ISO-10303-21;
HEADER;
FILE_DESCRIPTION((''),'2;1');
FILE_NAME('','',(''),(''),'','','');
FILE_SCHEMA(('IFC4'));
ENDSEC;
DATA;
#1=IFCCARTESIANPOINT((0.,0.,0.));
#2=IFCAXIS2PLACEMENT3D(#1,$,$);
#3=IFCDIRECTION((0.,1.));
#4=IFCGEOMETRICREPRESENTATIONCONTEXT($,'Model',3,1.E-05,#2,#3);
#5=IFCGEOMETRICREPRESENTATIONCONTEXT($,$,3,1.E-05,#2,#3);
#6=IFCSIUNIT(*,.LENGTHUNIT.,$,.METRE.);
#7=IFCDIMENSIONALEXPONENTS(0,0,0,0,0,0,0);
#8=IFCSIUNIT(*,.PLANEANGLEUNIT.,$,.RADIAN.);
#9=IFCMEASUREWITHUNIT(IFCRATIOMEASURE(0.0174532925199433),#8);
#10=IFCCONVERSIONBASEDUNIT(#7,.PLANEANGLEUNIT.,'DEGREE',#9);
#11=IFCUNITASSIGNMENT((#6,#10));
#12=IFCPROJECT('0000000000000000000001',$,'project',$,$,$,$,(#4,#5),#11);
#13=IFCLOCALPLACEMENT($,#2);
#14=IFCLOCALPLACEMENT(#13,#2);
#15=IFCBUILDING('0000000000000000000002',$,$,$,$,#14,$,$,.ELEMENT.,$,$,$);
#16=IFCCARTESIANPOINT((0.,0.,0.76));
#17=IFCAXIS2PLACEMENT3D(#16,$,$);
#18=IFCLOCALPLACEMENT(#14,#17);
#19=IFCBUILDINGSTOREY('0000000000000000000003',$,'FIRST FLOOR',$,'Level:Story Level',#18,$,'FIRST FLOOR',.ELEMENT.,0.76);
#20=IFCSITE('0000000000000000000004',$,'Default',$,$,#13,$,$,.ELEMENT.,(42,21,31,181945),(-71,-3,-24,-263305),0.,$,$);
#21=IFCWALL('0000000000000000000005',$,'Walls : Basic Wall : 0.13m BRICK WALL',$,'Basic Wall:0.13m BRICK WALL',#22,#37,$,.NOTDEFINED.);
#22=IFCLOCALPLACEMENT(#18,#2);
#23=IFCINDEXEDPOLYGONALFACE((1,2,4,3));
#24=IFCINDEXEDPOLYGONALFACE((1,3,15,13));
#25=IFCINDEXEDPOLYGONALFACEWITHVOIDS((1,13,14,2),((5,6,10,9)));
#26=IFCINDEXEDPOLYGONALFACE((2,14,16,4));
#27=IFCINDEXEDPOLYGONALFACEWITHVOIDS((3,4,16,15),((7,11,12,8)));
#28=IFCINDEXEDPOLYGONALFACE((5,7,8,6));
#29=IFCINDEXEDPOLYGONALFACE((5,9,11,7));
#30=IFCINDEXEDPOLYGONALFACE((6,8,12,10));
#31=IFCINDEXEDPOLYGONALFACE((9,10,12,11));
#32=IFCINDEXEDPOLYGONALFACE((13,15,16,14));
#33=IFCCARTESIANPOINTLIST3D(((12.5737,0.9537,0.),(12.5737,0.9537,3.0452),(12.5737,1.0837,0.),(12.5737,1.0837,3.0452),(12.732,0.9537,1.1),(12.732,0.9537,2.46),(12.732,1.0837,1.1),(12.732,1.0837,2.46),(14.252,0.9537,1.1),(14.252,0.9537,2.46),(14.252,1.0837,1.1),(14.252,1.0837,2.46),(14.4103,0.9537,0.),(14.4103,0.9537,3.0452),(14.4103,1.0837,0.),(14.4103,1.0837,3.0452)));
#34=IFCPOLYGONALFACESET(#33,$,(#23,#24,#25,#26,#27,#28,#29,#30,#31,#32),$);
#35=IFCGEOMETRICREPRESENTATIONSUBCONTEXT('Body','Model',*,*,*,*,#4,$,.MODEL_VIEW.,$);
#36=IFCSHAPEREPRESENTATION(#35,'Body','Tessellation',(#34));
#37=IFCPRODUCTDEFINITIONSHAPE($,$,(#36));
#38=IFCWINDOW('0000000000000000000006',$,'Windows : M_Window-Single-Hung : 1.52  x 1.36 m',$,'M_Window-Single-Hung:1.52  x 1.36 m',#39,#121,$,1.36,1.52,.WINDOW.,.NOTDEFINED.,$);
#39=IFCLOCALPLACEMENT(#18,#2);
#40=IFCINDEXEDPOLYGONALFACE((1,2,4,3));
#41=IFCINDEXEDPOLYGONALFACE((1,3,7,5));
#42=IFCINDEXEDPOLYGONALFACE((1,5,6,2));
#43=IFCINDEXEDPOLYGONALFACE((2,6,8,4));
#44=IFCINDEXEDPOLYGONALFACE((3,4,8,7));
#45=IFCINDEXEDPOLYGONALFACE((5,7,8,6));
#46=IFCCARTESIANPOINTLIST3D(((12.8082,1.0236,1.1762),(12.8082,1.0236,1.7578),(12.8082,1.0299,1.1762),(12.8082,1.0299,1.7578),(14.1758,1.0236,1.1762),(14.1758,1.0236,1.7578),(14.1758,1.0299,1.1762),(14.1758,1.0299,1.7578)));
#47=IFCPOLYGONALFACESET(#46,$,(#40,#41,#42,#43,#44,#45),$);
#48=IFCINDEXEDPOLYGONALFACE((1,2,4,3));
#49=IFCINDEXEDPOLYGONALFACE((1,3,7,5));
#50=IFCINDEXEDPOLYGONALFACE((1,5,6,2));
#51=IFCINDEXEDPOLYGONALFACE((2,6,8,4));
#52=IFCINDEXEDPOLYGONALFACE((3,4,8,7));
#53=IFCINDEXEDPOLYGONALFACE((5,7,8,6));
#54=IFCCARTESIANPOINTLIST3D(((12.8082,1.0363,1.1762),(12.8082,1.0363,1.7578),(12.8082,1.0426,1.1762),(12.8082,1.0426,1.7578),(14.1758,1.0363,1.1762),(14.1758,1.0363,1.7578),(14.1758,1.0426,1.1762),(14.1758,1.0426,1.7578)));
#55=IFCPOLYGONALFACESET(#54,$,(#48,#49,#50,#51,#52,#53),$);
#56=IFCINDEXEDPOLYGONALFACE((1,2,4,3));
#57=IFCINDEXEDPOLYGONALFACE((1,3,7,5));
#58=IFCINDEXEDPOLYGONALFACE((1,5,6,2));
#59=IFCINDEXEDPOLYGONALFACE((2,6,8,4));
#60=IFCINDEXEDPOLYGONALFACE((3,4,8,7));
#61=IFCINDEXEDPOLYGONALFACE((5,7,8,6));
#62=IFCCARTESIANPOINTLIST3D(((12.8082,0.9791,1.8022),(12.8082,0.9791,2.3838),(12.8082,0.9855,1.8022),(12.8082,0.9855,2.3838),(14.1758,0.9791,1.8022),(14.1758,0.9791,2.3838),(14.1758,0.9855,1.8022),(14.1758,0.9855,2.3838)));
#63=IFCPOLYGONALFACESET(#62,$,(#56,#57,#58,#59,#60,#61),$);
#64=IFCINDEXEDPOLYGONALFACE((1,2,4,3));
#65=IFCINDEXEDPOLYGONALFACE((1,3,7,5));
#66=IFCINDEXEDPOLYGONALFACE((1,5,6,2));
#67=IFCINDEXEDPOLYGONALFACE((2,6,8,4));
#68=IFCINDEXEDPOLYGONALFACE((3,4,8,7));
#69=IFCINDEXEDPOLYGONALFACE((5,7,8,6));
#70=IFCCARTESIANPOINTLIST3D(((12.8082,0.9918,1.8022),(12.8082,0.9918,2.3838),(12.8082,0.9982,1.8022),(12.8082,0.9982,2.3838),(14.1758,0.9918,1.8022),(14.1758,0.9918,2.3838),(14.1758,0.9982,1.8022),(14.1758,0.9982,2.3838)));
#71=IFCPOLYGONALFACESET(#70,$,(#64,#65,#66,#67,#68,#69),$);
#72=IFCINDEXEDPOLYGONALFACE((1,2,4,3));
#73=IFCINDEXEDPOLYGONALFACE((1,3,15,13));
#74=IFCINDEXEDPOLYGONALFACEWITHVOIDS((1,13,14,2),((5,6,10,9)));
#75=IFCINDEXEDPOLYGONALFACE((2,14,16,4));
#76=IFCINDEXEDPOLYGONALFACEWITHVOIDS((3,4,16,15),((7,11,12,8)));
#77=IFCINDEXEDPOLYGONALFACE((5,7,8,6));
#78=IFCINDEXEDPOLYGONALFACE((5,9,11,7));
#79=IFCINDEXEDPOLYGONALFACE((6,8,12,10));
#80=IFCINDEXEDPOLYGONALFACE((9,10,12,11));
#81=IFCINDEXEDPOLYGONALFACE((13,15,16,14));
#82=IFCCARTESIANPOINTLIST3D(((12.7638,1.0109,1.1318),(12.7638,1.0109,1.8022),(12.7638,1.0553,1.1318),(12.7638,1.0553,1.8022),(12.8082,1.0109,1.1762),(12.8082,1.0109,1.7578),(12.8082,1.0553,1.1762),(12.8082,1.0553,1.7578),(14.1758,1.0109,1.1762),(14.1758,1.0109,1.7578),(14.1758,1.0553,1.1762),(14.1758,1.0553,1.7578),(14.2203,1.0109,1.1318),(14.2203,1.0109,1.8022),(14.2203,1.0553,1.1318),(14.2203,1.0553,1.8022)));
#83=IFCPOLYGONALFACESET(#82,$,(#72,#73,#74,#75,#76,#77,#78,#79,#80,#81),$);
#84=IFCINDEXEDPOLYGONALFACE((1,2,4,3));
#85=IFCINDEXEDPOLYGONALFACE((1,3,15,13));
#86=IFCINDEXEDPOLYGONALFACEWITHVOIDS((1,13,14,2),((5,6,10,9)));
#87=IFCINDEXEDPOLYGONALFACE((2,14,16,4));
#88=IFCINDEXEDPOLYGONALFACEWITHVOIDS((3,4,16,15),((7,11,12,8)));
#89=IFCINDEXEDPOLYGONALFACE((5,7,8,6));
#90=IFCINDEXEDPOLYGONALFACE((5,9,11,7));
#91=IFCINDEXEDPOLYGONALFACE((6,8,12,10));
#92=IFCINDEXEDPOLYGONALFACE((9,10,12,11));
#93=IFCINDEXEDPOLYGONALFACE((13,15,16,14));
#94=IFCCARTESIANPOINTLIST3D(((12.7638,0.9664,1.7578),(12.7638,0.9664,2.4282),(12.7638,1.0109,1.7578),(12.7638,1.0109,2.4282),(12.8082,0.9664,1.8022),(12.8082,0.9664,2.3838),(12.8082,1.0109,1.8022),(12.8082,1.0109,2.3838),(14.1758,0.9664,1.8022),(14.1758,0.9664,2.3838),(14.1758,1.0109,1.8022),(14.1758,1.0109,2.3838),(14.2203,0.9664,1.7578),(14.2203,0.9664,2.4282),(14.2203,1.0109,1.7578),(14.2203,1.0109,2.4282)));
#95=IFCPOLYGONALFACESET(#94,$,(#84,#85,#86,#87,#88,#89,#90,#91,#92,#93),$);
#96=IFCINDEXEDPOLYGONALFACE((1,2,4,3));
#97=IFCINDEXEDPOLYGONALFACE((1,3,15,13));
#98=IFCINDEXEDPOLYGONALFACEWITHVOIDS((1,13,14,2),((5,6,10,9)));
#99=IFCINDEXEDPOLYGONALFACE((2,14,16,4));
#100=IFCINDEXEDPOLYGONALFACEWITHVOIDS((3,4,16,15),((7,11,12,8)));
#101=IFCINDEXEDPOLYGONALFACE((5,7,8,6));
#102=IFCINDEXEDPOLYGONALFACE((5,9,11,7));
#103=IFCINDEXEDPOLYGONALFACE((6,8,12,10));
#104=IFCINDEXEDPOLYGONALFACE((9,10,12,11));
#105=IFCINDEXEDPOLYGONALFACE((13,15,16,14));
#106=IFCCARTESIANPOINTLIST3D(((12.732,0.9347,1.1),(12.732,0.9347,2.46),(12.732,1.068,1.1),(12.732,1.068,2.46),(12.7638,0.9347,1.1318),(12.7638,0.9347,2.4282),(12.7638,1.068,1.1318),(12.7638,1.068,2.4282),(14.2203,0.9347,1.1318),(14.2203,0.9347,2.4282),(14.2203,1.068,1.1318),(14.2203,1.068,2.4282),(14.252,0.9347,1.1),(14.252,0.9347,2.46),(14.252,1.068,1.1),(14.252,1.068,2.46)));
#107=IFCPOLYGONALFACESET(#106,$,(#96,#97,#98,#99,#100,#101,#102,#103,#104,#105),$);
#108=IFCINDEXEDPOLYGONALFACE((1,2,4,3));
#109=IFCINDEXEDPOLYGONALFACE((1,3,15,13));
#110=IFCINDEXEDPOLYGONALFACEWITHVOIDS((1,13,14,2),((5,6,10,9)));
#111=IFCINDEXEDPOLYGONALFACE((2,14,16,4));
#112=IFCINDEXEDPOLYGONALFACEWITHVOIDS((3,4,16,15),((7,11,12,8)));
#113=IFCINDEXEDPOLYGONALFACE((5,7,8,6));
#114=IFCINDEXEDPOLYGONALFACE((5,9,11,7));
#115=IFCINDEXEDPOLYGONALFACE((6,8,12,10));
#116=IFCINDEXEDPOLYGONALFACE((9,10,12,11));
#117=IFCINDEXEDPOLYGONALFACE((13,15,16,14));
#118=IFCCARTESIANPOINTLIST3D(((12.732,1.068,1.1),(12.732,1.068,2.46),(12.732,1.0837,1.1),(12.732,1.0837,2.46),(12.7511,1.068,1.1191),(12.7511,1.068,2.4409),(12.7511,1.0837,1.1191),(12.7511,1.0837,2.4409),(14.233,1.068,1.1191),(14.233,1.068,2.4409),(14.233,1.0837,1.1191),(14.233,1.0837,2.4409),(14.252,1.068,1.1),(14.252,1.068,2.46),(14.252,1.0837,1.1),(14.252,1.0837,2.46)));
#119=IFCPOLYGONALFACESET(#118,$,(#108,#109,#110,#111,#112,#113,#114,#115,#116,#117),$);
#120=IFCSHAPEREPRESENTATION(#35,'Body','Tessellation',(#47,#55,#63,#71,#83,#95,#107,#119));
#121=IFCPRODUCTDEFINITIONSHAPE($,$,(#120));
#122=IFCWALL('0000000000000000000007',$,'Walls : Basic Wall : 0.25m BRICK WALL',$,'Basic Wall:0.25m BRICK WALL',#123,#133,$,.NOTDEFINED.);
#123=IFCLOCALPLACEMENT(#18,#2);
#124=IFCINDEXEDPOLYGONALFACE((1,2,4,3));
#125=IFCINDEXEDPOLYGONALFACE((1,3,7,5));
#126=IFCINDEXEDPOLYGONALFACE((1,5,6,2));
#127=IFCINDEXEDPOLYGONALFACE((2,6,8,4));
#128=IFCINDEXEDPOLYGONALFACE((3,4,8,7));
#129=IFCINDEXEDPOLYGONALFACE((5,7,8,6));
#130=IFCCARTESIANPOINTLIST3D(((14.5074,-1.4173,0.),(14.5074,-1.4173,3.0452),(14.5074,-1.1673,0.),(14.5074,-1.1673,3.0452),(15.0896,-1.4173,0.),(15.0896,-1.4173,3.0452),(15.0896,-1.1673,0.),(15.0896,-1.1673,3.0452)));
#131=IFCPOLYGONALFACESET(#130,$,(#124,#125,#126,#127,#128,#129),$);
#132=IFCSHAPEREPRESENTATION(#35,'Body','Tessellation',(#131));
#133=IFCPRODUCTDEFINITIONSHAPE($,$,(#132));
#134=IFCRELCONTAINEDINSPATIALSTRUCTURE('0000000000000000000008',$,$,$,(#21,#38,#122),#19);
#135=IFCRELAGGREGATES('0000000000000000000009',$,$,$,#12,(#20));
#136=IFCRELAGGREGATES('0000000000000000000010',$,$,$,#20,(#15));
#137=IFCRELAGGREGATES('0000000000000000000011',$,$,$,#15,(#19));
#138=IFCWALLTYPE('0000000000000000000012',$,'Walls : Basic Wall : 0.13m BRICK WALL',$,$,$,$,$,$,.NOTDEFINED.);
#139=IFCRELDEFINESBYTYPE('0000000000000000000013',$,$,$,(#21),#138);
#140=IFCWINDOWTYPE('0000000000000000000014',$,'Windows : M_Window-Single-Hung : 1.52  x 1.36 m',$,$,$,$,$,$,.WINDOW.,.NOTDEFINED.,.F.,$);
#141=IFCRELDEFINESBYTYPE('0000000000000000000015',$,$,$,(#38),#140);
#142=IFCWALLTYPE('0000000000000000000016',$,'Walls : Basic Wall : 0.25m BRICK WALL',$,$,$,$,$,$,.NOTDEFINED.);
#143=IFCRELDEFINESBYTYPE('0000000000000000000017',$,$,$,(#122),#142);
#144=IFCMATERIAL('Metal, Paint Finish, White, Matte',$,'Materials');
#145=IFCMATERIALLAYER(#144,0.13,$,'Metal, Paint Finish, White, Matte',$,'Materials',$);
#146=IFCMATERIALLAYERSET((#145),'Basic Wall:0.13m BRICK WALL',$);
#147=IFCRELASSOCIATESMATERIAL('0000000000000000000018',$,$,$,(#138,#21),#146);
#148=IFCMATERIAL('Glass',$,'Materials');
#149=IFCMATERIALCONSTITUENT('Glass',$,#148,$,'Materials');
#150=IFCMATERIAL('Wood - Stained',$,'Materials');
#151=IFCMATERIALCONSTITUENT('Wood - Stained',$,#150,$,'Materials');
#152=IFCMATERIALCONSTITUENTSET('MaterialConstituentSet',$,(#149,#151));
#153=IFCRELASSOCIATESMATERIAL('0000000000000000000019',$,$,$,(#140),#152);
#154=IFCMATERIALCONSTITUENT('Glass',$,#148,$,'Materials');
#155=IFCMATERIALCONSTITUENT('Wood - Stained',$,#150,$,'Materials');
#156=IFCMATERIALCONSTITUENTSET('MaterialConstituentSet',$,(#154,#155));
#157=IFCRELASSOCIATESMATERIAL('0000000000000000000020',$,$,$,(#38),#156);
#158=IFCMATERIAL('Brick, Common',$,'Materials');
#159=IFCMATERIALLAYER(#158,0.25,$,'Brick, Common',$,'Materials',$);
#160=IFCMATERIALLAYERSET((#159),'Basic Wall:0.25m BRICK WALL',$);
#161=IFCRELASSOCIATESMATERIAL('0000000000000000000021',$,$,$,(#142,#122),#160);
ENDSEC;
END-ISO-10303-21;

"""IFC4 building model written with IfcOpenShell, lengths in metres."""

from ifc_helpers import new_model, entity, si_unit, converted_unit, direction, frame, frame_2d, origin, origin_2d_with_axis, place, context, subcontext, project, spatial, polyline, rectangle, outline, extrude, source, transform, mapped, material, layer, layer_set, layer_usage, constituent, constituent_set, type_object, type_shapes, element, fill, save


model = new_model("IFC4")

# Units and contexts
model_context = context("Model", 3, precision=1e-05, world=origin(), true_north=direction((0.0, 1.0)))
context_of_model = context(None, 3, precision=1e-05, world=origin(), true_north=direction((0.0, 1.0)))
body_context = subcontext(model_context, "Body", "Model", "MODEL_VIEW")
ifc_project = project(units=[si_unit("LENGTHUNIT", "METRE"), converted_unit("PLANEANGLEUNIT", "DEGREE", entity("IfcRatioMeasure", 0.0174532925199433), si_unit("PLANEANGLEUNIT", "RADIAN"), dimensions=[0, 0, 0, 0, 0, 0, 0])], contexts=[model_context, context_of_model])

# Site, building, storey
site_placement = place(None, origin())
site = spatial("IfcSite", under=ifc_project, at=site_placement, Name="Default", CompositionType="ELEMENT", RefLatitude=(42, 21, 31, 181945), RefLongitude=(-71, -3, -24, -263305), RefElevation=0.0)
building_placement = place(site_placement, origin())
building = spatial("IfcBuilding", under=site, at=building_placement, CompositionType="ELEMENT")
storey_placement = place(building_placement, frame((0.0, 0.0, 0.76)))
storey = spatial("IfcBuildingStorey", under=building, at=storey_placement, Name="FIRST FLOOR", ObjectType="Level:Story Level", LongName="FIRST FLOOR", CompositionType="ELEMENT", Elevation=0.76)

# Wall, opening, window
ifc_material_1 = material(Name="Metal, Paint Finish, White, Matte", Category="Materials")
ifc_layer_1 = layer(ifc_material_1, 0.13, Name="Metal, Paint Finish, White, Matte", Category="Materials")
ifc_layer_set_1 = layer_set([ifc_layer_1], Name="Basic Wall:0.13m BRICK WALL")
wall_type_1 = type_object("IfcWallType", Name="Walls : Basic Wall : 0.13m BRICK WALL", PredefinedType="NOTDEFINED", material=ifc_layer_set_1)
ifc_material_2 = material(Name="Glass", Category="Materials")
ifc_material_3 = material(Name="Wood - Stained", Category="Materials")
ifc_layer_usage_1 = layer_usage(ifc_layer_set_1, "AXIS2", "NEGATIVE", 0.065)
wall_1_placement = place(storey_placement, frame((12.5737, 1.0187, 0.0)))
wall_1 = element("IfcWall", 1, at=wall_1_placement, inside=storey, type_object=wall_type_1, material=ifc_layer_usage_1, Name="Walls : Basic Wall : 0.13m BRICK WALL", ObjectType="Basic Wall:0.13m BRICK WALL", PredefinedType="NOTDEFINED", context=body_context, shape_type="SweptSolid", body=[
    extrude(rectangle(XDim=1.8366, YDim=0.13, at=frame_2d((0.9183, 0.0), x_axis=(-1.0, 0.0))), origin(), (0.0, 0.0, 1.0), 3.0452),
])
opening_1_placement = place(wall_1_placement, frame((1.6783, 0.065, 1.1)))
opening_1 = element("IfcOpeningElement", 2, at=opening_1_placement, cuts=wall_1, ObjectType="Opening", PredefinedType="OPENING", context=body_context, shape_type="SweptSolid", body=[
    extrude(rectangle(XDim=1.36, YDim=1.52, at=frame_2d((0.68, 0.76), x_axis=(-1.0, 0.0))), frame((0.0, 0.0, 0.0), z_axis=(0.0, -1.0, 0.0), x_axis=(0.0, 0.0, 1.0)), (0.0, 0.0, 1.0), 0.13),
])
ifc_constituent_1 = constituent(ifc_material_2, Name="Glass", Category="Materials")
ifc_constituent_2 = constituent(ifc_material_3, Name="Wood - Stained", Category="Materials")
ifc_constituent_set_1 = constituent_set(constituents=[ifc_constituent_1, ifc_constituent_2], Name="MaterialConstituentSet")
ifc_constituent_3 = constituent(ifc_material_2, Name="Glass", Category="Materials")
ifc_constituent_4 = constituent(ifc_material_3, Name="Wood - Stained", Category="Materials")
ifc_constituent_set_2 = constituent_set(constituents=[ifc_constituent_3, ifc_constituent_4], Name="MaterialConstituentSet")
window_type_1 = type_object("IfcWindowType", Name="Windows : M_Window-Single-Hung : 1.52  x 1.36 m", ParameterTakesPrecedence=False, PartitioningType="NOTDEFINED", PredefinedType="WINDOW", material=ifc_constituent_set_2)
shared_shape_1 = source(origin(), body_context, "Body", "SweptSolid", [
    extrude(rectangle(XDim=1.3676, YDim=0.0063, at=origin_2d_with_axis()), frame((0.76, 0.057, 0.0762), z_axis=(0.0, 0.0, 1.0), x_axis=(-1.0, 0.0, 0.0)), (0.0, 0.0, 1.0), 0.5816),
    extrude(rectangle(XDim=0.0063, YDim=1.3676, at=origin_2d_with_axis()), frame((0.76, 0.0443, 0.0762), z_axis=(0.0, 0.0, 1.0), x_axis=(0.0, -1.0, 0.0)), (0.0, 0.0, 1.0), 0.5816),
    extrude(rectangle(XDim=1.3676, YDim=0.0063, at=frame_2d((0.0, 0.0), x_axis=(1.0, 0.0))), frame((0.76, 0.1014, 0.7022), z_axis=(0.0, 0.0, 1.0), x_axis=(-1.0, 0.0, 0.0)), (0.0, 0.0, 1.0), 0.5816),
    extrude(rectangle(XDim=0.0063, YDim=1.3676, at=origin_2d_with_axis()), frame((0.76, 0.0887, 0.7022), z_axis=(0.0, 0.0, 1.0), x_axis=(0.0, -1.0, 0.0)), (0.0, 0.0, 1.0), 0.5816),
    extrude(outline(polyline([(-0.7282, -0.3352), (0.7282, -0.3352), (0.7282, 0.3352), (-0.7282, 0.3352), (-0.7282, -0.3352)]), holes=[polyline([(0.6838, -0.2908), (-0.6838, -0.2908), (-0.6838, 0.2908), (0.6838, 0.2908), (0.6838, -0.2908)])]), frame((0.76, 0.0284, 0.367), z_axis=(0.0, 1.0, 0.0), x_axis=(1.0, 0.0, 0.0)), (0.0, 0.0, 1.0), 0.0445),
    extrude(outline(polyline([(-0.7282, -0.3352), (0.7282, -0.3352), (0.7282, 0.3352), (-0.7282, 0.3352), (-0.7282, -0.3352)]), holes=[polyline([(0.6838, -0.2908), (-0.6838, -0.2908), (-0.6838, 0.2908), (0.6838, 0.2908), (0.6838, -0.2908)])]), frame((0.76, 0.0728, 0.993), z_axis=(0.0, 1.0, 0.0), x_axis=(1.0, 0.0, 0.0)), (0.0, 0.0, 1.0), 0.0445),
    extrude(outline(polyline([(-0.76, -0.68), (0.76, -0.68), (0.76, 0.68), (-0.76, 0.68), (-0.76, -0.68)]), holes=[polyline([(0.7282, -0.6482), (-0.7282, -0.6482), (-0.7282, 0.6482), (0.7282, 0.6482), (0.7282, -0.6482)])]), frame((0.76, 0.0157, 0.68), z_axis=(0.0, 1.0, 0.0), x_axis=(1.0, 0.0, 0.0)), (0.0, 0.0, 1.0), 0.1333),
    extrude(outline(polyline([(-0.68, -0.76), (0.68, -0.76), (0.68, 0.76), (-0.68, 0.76), (-0.68, -0.76)]), holes=[polyline([(-0.6609, -0.7409), (-0.6609, 0.7409), (0.6609, 0.7409), (0.6609, -0.7409), (-0.6609, -0.7409)])]), frame((0.76, 0.0, 0.68), z_axis=(0.0, 1.0, 0.0), x_axis=(0.0, 0.0, -1.0)), (0.0, 0.0, 1.0), 0.0157),
])
type_shapes(window_type_1, [shared_shape_1])
window_1_placement = place(opening_1_placement, frame((0.0, 0.0, 0.0), z_axis=(0.0, 0.0, 1.0), x_axis=(-1.0, 0.0, 0.0)))
window_1 = element("IfcWindow", 3, at=window_1_placement, inside=storey, type_object=window_type_1, material=ifc_constituent_set_1, Name="Windows : M_Window-Single-Hung : 1.52  x 1.36 m", ObjectType="M_Window-Single-Hung:1.52  x 1.36 m", OverallHeight=1.36, OverallWidth=1.52, PartitioningType="NOTDEFINED", PredefinedType="WINDOW", context=body_context, shape_type="MappedRepresentation", body=[
    mapped(shared_shape_1, transform((0.0, 0.0, 0.0), scale=1.0)),
])
fill(opening_1, window_1)

# Wall
ifc_material_4 = material(Name="Brick, Common", Category="Materials")
ifc_layer_2 = layer(ifc_material_4, 0.25, Name="Brick, Common", Category="Materials")
ifc_layer_set_2 = layer_set([ifc_layer_2], Name="Basic Wall:0.25m BRICK WALL")
ifc_layer_usage_2 = layer_usage(ifc_layer_set_2, "AXIS2", "NEGATIVE", 0.125)
wall_type_2 = type_object("IfcWallType", Name="Walls : Basic Wall : 0.25m BRICK WALL", PredefinedType="NOTDEFINED", material=ifc_layer_set_2)
wall_2_placement = place(storey_placement, frame((15.0896, -1.2923, 0.0), z_axis=(0.0, 0.0, 1.0), x_axis=(-1.0, 0.0, 0.0)))
element("IfcWall", 4, at=wall_2_placement, inside=storey, type_object=wall_type_2, material=ifc_layer_usage_2, Name="Walls : Basic Wall : 0.25m BRICK WALL", ObjectType="Basic Wall:0.25m BRICK WALL", PredefinedType="NOTDEFINED", context=body_context, shape_type="SweptSolid", body=[
    extrude(rectangle(XDim=0.5822, YDim=0.25, at=frame_2d((0.2911, 0.0), x_axis=(-1.0, 0.0))), origin(), (0.0, 0.0, 1.0), 3.0452),
])

save(model, "model.ifc")
